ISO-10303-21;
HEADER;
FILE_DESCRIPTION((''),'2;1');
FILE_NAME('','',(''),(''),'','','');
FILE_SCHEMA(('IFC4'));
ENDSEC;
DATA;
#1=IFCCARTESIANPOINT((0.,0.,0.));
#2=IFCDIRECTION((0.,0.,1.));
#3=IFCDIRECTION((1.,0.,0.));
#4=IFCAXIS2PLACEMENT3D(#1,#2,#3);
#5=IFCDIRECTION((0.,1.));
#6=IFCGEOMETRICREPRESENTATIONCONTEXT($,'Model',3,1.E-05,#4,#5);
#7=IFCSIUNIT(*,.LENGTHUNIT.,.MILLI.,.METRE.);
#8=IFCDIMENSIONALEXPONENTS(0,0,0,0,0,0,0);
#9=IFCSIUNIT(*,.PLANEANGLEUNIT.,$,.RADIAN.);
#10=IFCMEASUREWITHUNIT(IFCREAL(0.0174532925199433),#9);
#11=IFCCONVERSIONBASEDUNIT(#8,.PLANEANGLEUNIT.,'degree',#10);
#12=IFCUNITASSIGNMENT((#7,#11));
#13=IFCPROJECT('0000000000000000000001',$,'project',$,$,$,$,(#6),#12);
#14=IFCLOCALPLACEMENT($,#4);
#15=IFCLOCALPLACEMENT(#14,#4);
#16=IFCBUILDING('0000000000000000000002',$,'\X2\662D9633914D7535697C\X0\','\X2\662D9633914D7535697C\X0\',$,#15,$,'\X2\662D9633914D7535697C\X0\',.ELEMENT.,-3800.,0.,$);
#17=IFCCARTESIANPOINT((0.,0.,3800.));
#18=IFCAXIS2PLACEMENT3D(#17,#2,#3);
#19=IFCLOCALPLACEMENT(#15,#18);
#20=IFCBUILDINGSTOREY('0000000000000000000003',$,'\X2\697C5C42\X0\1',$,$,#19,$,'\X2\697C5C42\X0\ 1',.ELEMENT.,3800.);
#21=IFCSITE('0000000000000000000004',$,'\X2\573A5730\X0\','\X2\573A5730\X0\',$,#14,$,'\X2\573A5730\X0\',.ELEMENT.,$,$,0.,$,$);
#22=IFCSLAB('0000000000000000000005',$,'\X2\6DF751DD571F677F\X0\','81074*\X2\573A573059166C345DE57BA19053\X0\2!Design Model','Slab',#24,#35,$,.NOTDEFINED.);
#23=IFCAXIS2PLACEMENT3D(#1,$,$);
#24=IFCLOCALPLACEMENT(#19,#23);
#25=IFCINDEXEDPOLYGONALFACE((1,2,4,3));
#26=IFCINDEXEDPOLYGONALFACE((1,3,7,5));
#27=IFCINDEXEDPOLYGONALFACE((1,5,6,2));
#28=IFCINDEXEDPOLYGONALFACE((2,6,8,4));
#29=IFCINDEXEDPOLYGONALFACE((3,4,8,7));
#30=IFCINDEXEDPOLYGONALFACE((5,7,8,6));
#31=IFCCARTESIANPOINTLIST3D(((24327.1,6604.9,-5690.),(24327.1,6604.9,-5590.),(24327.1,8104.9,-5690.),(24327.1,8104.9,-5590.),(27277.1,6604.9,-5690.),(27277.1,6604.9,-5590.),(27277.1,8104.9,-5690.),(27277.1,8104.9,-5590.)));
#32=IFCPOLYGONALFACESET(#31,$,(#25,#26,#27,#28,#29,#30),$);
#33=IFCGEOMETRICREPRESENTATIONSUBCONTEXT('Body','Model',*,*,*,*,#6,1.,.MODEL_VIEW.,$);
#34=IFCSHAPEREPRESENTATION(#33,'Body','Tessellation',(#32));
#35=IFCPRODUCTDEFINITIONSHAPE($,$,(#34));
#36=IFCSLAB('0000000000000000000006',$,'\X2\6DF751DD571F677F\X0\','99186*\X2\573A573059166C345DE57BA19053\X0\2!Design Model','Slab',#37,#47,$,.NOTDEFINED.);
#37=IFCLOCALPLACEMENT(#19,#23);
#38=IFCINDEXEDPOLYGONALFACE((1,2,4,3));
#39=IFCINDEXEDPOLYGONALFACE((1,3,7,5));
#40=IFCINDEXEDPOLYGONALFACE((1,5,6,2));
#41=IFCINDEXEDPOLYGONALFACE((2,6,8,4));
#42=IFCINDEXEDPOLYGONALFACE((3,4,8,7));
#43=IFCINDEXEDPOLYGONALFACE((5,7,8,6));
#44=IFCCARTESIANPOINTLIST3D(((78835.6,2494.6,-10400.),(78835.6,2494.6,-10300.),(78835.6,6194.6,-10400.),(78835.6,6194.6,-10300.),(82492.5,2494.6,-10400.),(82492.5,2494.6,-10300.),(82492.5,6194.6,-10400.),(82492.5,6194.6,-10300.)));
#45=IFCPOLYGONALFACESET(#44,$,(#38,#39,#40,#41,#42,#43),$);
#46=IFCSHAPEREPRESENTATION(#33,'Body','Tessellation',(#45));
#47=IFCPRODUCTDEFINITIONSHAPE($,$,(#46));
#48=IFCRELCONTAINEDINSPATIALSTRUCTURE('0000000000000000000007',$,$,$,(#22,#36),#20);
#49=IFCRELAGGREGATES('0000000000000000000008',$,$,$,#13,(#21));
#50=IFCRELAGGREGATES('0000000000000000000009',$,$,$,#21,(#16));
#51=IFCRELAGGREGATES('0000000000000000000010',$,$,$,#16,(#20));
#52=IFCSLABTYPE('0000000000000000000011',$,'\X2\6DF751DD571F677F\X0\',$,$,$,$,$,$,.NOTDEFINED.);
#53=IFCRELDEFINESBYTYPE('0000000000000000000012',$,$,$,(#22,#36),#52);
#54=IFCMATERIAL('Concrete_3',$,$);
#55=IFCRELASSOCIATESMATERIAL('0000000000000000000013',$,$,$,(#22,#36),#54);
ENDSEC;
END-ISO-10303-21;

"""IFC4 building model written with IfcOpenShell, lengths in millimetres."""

from ifc_helpers import new_model, entity, si_unit, converted_unit, direction, frame, origin_with_axes, place, context, subcontext, project, spatial, line, indexed_curve, outline, extrude, material, type_object, element, save


model = new_model("IFC4")

# Units and contexts
model_context = context("Model", 3, precision=1e-05, world=origin_with_axes(), true_north=direction((0.0, 1.0)))
body_context = subcontext(model_context, "Body", "Model", "MODEL_VIEW", scale=1.0)
ifc_project = project(units=[si_unit("LENGTHUNIT", "METRE", prefix="MILLI"), converted_unit("PLANEANGLEUNIT", "degree", entity("IfcReal", 0.0174532925199433), si_unit("PLANEANGLEUNIT", "RADIAN"), dimensions=[0, 0, 0, 0, 0, 0, 0])], contexts=[model_context])

# Site, building, storey
site_placement = place(None, origin_with_axes())
site = spatial("IfcSite", under=ifc_project, at=site_placement, Name="场地", Description="场地", LongName="场地", CompositionType="ELEMENT", RefElevation=0.0)
building_placement = place(site_placement, origin_with_axes())
building = spatial("IfcBuilding", under=site, at=building_placement, Name="昭阳配电楼", Description="昭阳配电楼", LongName="昭阳配电楼", CompositionType="ELEMENT", ElevationOfRefHeight=-3800.0, ElevationOfTerrain=0.0)
storey_placement = place(building_placement, frame((0.0, 0.0, 3800.0), z_axis=(0.0, 0.0, 1.0), x_axis=(1.0, 0.0, 0.0)))
storey = spatial("IfcBuildingStorey", under=building, at=storey_placement, Name="楼层1", LongName="楼层 1", CompositionType="ELEMENT", Elevation=3800.0)

# Slabs
ifc_material = material(Name="Concrete_3")
slab_type = type_object("IfcSlabType", Name="混凝土板", PredefinedType="NOTDEFINED")
slab_1_placement = place(storey_placement, frame((24327.1, 8104.9, -5590.0), z_axis=(0.0, 0.0, 1.0), x_axis=(-1.0, 0.0, 0.0)))
element("IfcSlab", 1, at=slab_1_placement, inside=storey, type_object=slab_type, material=ifc_material, Name="混凝土板", Description="81074*场地外水工管道2!Design Model", ObjectType="Slab", PredefinedType="NOTDEFINED", context=body_context, shape_type="SweptSolid", body=[
    extrude(outline(indexed_curve([(0.0, 0.0), (2950.0, 0.0), (2950.0, 1500.0), (0.0, 1500.0)], segments=[line(1, 2, 3, 4, 1)], self_intersect=False)), frame((0.0, 0.0, 0.0), z_axis=(0.0, 0.0, -1.0), x_axis=(-1.0, 0.0, 0.0)), (0.0, 0.0, 1.0), 100.0),
])
slab_2_placement = place(storey_placement, frame((78835.6, 6194.6, -10300.0), z_axis=(0.0, 0.0, 1.0), x_axis=(-1.0, 0.0, 0.0)))
element("IfcSlab", 2, at=slab_2_placement, inside=storey, type_object=slab_type, material=ifc_material, Name="混凝土板", Description="99186*场地外水工管道2!Design Model", ObjectType="Slab", PredefinedType="NOTDEFINED", context=body_context, shape_type="SweptSolid", body=[
    extrude(outline(indexed_curve([(0.0, 0.0), (3656.9, 0.0), (3656.9, 3700.0), (0.0, 3700.0)], segments=[line(1, 2, 3, 4, 1)], self_intersect=False)), frame((0.0, 0.0, 0.0), z_axis=(0.0, 0.0, -1.0), x_axis=(-1.0, 0.0, 0.0)), (0.0, 0.0, 1.0), 100.0),
])

save(model, "model.ifc")
